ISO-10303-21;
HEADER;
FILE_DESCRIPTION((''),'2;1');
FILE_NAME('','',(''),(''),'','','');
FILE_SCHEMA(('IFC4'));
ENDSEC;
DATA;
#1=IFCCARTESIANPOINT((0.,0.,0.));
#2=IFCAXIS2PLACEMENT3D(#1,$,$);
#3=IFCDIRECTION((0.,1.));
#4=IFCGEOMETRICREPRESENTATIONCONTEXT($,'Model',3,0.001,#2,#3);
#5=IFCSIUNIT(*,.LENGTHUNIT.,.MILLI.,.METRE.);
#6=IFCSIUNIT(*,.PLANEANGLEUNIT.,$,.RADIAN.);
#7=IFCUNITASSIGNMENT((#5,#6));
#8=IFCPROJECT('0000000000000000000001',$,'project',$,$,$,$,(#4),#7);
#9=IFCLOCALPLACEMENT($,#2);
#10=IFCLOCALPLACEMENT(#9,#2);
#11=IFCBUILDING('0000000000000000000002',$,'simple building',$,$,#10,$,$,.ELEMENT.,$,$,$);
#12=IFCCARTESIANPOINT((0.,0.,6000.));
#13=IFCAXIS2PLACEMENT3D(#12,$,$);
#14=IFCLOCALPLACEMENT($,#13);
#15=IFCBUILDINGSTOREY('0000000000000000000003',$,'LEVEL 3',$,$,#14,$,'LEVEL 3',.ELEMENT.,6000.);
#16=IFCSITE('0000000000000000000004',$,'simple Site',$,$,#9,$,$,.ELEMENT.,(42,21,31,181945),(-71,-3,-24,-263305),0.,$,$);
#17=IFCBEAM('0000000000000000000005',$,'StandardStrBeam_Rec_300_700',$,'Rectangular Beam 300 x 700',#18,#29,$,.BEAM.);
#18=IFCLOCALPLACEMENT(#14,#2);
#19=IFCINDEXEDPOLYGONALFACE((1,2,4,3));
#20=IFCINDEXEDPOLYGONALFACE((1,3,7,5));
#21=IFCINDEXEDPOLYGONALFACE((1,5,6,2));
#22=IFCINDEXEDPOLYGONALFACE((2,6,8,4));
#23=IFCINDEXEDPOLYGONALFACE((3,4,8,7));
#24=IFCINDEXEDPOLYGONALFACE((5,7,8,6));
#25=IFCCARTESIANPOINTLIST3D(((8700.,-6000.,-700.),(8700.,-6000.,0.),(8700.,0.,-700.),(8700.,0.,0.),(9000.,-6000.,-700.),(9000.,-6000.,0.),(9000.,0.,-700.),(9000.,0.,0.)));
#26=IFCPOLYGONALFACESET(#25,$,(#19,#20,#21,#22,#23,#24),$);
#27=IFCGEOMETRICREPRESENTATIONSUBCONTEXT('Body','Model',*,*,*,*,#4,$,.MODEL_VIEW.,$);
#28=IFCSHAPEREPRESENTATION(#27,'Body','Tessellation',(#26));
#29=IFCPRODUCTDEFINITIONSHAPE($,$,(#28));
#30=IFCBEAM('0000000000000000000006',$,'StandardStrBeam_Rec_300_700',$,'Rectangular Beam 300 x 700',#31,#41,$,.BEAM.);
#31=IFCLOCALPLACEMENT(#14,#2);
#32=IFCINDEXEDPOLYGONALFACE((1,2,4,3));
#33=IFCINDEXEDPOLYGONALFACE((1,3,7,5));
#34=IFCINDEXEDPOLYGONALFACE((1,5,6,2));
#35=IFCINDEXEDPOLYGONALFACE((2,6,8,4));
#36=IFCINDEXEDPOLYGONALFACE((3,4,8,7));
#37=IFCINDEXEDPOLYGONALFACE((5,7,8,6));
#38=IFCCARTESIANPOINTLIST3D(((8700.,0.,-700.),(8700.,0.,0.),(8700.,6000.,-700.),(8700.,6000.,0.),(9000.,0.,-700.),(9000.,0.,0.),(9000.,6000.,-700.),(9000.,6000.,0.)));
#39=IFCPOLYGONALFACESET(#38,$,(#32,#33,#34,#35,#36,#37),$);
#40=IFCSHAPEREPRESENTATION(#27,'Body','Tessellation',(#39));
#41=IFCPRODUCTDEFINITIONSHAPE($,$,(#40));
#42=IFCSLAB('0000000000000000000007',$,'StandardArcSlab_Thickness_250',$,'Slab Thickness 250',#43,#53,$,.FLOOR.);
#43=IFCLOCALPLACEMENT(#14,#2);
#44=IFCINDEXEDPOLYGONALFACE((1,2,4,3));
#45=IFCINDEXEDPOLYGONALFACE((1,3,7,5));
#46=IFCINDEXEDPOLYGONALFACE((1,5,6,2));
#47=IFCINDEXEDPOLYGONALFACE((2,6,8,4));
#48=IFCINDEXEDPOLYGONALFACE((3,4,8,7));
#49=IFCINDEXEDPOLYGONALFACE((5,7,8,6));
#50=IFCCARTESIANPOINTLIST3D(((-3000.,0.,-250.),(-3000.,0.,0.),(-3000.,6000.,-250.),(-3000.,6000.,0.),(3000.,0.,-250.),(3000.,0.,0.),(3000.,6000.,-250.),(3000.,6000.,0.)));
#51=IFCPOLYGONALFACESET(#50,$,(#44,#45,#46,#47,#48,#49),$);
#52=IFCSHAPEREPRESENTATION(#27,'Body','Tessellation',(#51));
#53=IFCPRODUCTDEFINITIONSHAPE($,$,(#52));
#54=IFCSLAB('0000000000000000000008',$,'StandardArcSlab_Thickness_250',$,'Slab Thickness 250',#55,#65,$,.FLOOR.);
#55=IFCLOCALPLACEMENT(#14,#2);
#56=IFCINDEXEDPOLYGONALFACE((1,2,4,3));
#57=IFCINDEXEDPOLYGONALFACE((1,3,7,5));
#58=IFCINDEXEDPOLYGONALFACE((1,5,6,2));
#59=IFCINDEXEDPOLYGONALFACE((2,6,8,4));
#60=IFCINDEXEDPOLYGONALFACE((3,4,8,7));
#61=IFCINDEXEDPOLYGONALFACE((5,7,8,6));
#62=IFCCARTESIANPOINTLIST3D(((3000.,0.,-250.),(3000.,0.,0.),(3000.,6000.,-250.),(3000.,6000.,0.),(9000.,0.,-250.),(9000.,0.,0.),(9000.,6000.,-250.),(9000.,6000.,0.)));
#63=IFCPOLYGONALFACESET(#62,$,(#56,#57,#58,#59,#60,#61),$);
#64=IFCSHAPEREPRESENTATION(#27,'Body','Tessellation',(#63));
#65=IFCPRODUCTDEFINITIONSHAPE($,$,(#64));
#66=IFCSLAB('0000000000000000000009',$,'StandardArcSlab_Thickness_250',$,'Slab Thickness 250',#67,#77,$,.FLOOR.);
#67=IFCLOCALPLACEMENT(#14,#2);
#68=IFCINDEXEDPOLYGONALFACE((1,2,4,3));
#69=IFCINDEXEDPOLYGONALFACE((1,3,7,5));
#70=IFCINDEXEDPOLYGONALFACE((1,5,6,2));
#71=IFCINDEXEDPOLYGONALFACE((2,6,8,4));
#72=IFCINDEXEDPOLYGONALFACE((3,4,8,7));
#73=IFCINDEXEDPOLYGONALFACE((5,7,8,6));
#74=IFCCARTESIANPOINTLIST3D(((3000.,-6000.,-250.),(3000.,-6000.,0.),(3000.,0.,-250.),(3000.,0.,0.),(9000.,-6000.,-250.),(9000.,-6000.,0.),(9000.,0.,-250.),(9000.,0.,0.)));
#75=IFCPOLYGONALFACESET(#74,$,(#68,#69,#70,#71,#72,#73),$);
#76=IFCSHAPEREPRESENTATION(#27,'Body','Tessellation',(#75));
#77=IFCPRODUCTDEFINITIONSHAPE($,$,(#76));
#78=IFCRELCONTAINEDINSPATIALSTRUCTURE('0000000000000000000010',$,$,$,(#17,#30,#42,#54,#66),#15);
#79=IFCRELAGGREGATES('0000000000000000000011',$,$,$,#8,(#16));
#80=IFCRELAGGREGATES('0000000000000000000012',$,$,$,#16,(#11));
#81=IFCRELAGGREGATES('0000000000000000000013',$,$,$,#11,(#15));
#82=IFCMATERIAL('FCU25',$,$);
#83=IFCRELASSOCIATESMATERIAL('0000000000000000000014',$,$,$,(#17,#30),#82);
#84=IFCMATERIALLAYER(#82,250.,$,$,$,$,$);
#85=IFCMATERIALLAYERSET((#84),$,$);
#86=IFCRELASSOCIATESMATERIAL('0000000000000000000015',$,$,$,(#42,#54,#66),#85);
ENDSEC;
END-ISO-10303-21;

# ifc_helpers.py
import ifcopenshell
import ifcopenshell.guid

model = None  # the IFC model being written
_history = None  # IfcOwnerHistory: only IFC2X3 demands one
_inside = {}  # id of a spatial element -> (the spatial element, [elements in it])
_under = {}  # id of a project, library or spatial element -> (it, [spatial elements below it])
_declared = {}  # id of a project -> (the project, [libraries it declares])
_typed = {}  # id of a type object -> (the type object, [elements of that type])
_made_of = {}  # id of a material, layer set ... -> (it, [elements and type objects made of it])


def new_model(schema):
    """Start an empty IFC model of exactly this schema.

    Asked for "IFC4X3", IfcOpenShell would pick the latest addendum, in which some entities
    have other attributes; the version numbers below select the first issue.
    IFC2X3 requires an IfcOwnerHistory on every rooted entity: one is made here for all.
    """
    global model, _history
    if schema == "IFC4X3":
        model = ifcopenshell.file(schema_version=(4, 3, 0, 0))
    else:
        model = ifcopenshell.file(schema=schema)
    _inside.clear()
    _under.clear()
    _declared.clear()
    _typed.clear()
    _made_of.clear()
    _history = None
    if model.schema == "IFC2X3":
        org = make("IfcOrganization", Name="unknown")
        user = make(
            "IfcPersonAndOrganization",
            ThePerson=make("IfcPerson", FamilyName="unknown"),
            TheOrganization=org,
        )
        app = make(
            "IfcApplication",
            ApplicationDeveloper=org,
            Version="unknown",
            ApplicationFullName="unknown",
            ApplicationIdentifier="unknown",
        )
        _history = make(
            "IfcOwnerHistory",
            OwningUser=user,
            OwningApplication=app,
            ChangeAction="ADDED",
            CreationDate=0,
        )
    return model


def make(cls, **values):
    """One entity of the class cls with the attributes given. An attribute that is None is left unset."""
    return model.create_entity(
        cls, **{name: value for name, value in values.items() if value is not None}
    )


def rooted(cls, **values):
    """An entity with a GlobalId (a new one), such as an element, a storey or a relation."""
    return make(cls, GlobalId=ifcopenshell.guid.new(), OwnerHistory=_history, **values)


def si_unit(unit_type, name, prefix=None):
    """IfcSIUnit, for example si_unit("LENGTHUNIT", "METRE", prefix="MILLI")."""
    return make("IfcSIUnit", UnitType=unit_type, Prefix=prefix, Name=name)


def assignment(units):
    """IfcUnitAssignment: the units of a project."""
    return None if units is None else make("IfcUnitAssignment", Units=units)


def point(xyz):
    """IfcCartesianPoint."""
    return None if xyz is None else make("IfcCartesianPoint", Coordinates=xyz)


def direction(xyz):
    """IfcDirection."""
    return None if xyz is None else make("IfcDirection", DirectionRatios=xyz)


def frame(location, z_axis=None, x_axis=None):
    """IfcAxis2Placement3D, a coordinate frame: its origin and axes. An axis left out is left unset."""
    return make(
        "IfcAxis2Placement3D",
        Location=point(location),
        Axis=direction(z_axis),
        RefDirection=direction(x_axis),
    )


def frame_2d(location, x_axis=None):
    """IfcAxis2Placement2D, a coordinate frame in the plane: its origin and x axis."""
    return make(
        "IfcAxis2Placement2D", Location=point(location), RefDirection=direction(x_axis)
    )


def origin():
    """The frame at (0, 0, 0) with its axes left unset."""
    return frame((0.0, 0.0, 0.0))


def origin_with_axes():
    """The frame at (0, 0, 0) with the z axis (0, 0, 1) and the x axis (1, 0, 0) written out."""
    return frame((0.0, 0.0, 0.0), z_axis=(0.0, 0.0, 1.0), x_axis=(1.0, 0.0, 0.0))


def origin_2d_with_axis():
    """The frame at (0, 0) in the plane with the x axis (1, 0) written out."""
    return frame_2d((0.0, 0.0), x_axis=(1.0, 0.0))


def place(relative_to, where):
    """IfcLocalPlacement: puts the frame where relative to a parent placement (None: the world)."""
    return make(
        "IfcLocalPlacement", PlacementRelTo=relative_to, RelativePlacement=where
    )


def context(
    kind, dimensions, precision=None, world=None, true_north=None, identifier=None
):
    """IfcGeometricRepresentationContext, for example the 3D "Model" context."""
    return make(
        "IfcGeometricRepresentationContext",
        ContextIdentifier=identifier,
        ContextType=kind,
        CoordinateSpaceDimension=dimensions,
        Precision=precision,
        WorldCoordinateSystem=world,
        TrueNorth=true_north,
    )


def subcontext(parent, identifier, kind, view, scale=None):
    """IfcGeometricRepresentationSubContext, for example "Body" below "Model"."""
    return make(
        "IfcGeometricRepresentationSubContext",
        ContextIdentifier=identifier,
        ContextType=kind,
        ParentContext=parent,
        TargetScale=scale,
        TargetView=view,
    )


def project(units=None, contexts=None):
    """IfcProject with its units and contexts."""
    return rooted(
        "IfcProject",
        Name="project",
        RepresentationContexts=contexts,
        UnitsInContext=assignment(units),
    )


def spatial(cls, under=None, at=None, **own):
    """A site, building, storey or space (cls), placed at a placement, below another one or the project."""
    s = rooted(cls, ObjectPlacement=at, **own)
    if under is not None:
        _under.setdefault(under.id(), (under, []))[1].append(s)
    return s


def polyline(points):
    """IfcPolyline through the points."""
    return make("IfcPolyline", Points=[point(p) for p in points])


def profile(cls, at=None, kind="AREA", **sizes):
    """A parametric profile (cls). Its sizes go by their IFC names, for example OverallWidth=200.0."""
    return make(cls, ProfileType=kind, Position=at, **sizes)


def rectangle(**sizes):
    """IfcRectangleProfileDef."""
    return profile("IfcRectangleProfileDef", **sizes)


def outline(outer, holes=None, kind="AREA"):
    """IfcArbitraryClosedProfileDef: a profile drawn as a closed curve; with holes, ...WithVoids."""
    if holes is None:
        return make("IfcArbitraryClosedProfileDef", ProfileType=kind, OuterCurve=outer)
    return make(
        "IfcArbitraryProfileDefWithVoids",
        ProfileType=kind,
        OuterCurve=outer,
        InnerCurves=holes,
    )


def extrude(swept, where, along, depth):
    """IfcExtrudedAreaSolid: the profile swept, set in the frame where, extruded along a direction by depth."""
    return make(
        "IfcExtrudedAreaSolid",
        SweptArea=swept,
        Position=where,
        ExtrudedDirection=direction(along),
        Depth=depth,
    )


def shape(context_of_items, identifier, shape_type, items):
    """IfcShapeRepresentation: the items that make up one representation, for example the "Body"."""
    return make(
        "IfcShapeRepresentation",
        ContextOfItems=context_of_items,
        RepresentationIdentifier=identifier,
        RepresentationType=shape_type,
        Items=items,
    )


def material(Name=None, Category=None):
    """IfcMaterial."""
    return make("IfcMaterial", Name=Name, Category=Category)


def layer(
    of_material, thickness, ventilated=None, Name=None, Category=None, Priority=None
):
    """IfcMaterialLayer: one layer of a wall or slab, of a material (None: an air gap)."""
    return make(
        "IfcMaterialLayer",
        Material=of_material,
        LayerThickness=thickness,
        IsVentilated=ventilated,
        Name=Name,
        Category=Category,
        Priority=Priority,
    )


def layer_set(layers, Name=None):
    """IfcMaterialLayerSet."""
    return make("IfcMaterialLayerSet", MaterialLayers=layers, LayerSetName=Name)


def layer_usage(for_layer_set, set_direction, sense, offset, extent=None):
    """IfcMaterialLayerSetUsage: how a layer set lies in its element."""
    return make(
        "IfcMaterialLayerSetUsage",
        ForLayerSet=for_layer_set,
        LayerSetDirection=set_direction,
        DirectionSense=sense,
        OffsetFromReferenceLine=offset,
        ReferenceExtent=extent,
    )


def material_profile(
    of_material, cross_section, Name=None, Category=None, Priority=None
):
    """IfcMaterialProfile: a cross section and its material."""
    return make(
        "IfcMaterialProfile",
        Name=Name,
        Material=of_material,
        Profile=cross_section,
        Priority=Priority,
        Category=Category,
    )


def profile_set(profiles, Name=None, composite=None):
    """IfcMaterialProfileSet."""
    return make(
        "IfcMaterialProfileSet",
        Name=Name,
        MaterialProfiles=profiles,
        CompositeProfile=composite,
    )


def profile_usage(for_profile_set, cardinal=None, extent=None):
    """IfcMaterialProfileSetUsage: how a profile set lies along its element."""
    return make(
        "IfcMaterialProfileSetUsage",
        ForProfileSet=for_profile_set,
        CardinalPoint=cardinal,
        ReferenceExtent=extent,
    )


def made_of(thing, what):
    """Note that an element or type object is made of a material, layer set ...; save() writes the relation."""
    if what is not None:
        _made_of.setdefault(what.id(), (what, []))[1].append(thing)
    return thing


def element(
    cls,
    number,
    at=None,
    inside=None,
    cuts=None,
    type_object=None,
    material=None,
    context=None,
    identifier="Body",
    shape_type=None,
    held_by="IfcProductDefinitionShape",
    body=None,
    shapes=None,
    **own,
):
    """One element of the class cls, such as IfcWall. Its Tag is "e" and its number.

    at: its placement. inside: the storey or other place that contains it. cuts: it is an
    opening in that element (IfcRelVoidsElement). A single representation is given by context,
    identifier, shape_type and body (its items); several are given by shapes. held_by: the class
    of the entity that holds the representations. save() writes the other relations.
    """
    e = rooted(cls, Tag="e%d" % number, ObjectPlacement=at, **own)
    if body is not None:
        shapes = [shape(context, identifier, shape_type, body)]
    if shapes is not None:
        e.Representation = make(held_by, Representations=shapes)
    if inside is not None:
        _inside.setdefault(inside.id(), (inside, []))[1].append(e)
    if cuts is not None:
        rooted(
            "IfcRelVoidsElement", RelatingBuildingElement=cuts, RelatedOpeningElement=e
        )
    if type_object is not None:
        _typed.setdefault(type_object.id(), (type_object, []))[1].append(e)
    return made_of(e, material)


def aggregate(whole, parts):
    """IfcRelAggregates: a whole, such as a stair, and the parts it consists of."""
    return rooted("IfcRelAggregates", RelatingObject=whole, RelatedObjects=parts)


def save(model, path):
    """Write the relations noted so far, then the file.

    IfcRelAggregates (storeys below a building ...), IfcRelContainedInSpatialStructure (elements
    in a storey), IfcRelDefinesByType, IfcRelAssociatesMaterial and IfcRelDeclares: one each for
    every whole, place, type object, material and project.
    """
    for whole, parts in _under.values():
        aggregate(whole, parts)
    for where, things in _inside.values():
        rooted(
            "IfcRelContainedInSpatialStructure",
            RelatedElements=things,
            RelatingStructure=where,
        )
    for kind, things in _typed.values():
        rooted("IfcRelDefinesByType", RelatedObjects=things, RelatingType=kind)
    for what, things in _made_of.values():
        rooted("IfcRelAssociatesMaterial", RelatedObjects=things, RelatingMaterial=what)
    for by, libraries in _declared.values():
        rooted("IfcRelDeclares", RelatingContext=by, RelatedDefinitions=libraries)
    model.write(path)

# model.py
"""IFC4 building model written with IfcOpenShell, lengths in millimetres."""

from ifc_helpers import new_model, si_unit, direction, frame, origin, origin_with_axes, origin_2d_with_axis, place, context, subcontext, project, spatial, polyline, rectangle, outline, extrude, material, layer, layer_set, layer_usage, material_profile, profile_set, profile_usage, element, save


model = new_model("IFC4")

# Units and contexts
model_context = context("Model", 3, precision=0.001, world=origin(), true_north=direction((0.0, 1.0)))
body_context = subcontext(model_context, "Body", "Model", "MODEL_VIEW")
ifc_project = project(units=[si_unit("LENGTHUNIT", "METRE", prefix="MILLI"), si_unit("PLANEANGLEUNIT", "RADIAN")], contexts=[model_context])

# Site, building, storey
site_placement = place(None, origin())
site = spatial("IfcSite", under=ifc_project, at=site_placement, Name="simple Site", CompositionType="ELEMENT", RefLatitude=(42, 21, 31, 181945), RefLongitude=(-71, -3, -24, -263305), RefElevation=0.0)
building_placement = place(site_placement, origin())
building = spatial("IfcBuilding", under=site, at=building_placement, Name="simple building", CompositionType="ELEMENT")
storey_placement = place(None, frame((0.0, 0.0, 6000.0)))
storey = spatial("IfcBuildingStorey", under=building, at=storey_placement, Name="LEVEL 3", LongName="LEVEL 3", CompositionType="ELEMENT", Elevation=6000.0)

# Beams
ifc_material_1 = material(Name="FCU25")
ifc_material_profile_1 = material_profile(ifc_material_1, rectangle(XDim=300.0, YDim=700.0, at=origin_2d_with_axis()))
ifc_profile_set_1 = profile_set([ifc_material_profile_1])
ifc_profile_usage_1 = profile_usage(ifc_profile_set_1, cardinal=9)
for number, where, z_axis, x_axis, name in (
    (1, (8850.0, -6000.0, 5650.0), (0.0, 1.0, 0.0), (1.0, 0.0, 0.0), "StandardStrBeam_Rec_300_700"),
    (2, (8850.0, 0.0, 5650.0), (0.0, 1.0, 0.0), (1.0, 0.0, 0.0), "StandardStrBeam_Rec_300_700"),
):
    element("IfcBeam", number, at=place(None, frame(where, z_axis=z_axis, x_axis=x_axis)), inside=storey, material=ifc_profile_usage_1, Name=name, ObjectType="Rectangular Beam 300 x 700", PredefinedType="BEAM", context=body_context, shape_type="SweptSolid", body=[
        extrude(rectangle(XDim=300.0, YDim=700.0, at=origin_2d_with_axis()), origin_with_axes(), (0.0, 0.0, 1.0), 6000.0),
    ])

# Slabs
ifc_layer = layer(ifc_material_1, 250.0)
ifc_layer_set = layer_set([ifc_layer])
ifc_layer_usage = layer_usage(ifc_layer_set, "AXIS3", "POSITIVE", -250.0)
for number, where, z_axis, x_axis, name in (
    (3, (-3000.0, 0.0, 5750.0), (0.0, 0.0, 1.0), (1.0, 0.0, 0.0), "StandardArcSlab_Thickness_250"),
    (4, (3000.0, 0.0, 5750.0), (0.0, 0.0, 1.0), (1.0, 0.0, 0.0), "StandardArcSlab_Thickness_250"),
    (5, (3000.0, -6000.0, 5750.0), (0.0, 0.0, 1.0), (1.0, 0.0, 0.0), "StandardArcSlab_Thickness_250"),
):
    element("IfcSlab", number, at=place(None, frame(where, z_axis=z_axis, x_axis=x_axis)), inside=storey, material=ifc_layer_usage, Name=name, ObjectType="Slab Thickness 250", PredefinedType="FLOOR", context=body_context, shape_type="SweptSolid", body=[
        extrude(outline(polyline([(0.0, 0.0), (6000.0, 0.0), (6000.0, 6000.0), (0.0, 6000.0), (0.0, 0.0)])), origin_with_axes(), (0.0, 0.0, 1.0), 250.0),
    ])

save(model, "model.ifc")
